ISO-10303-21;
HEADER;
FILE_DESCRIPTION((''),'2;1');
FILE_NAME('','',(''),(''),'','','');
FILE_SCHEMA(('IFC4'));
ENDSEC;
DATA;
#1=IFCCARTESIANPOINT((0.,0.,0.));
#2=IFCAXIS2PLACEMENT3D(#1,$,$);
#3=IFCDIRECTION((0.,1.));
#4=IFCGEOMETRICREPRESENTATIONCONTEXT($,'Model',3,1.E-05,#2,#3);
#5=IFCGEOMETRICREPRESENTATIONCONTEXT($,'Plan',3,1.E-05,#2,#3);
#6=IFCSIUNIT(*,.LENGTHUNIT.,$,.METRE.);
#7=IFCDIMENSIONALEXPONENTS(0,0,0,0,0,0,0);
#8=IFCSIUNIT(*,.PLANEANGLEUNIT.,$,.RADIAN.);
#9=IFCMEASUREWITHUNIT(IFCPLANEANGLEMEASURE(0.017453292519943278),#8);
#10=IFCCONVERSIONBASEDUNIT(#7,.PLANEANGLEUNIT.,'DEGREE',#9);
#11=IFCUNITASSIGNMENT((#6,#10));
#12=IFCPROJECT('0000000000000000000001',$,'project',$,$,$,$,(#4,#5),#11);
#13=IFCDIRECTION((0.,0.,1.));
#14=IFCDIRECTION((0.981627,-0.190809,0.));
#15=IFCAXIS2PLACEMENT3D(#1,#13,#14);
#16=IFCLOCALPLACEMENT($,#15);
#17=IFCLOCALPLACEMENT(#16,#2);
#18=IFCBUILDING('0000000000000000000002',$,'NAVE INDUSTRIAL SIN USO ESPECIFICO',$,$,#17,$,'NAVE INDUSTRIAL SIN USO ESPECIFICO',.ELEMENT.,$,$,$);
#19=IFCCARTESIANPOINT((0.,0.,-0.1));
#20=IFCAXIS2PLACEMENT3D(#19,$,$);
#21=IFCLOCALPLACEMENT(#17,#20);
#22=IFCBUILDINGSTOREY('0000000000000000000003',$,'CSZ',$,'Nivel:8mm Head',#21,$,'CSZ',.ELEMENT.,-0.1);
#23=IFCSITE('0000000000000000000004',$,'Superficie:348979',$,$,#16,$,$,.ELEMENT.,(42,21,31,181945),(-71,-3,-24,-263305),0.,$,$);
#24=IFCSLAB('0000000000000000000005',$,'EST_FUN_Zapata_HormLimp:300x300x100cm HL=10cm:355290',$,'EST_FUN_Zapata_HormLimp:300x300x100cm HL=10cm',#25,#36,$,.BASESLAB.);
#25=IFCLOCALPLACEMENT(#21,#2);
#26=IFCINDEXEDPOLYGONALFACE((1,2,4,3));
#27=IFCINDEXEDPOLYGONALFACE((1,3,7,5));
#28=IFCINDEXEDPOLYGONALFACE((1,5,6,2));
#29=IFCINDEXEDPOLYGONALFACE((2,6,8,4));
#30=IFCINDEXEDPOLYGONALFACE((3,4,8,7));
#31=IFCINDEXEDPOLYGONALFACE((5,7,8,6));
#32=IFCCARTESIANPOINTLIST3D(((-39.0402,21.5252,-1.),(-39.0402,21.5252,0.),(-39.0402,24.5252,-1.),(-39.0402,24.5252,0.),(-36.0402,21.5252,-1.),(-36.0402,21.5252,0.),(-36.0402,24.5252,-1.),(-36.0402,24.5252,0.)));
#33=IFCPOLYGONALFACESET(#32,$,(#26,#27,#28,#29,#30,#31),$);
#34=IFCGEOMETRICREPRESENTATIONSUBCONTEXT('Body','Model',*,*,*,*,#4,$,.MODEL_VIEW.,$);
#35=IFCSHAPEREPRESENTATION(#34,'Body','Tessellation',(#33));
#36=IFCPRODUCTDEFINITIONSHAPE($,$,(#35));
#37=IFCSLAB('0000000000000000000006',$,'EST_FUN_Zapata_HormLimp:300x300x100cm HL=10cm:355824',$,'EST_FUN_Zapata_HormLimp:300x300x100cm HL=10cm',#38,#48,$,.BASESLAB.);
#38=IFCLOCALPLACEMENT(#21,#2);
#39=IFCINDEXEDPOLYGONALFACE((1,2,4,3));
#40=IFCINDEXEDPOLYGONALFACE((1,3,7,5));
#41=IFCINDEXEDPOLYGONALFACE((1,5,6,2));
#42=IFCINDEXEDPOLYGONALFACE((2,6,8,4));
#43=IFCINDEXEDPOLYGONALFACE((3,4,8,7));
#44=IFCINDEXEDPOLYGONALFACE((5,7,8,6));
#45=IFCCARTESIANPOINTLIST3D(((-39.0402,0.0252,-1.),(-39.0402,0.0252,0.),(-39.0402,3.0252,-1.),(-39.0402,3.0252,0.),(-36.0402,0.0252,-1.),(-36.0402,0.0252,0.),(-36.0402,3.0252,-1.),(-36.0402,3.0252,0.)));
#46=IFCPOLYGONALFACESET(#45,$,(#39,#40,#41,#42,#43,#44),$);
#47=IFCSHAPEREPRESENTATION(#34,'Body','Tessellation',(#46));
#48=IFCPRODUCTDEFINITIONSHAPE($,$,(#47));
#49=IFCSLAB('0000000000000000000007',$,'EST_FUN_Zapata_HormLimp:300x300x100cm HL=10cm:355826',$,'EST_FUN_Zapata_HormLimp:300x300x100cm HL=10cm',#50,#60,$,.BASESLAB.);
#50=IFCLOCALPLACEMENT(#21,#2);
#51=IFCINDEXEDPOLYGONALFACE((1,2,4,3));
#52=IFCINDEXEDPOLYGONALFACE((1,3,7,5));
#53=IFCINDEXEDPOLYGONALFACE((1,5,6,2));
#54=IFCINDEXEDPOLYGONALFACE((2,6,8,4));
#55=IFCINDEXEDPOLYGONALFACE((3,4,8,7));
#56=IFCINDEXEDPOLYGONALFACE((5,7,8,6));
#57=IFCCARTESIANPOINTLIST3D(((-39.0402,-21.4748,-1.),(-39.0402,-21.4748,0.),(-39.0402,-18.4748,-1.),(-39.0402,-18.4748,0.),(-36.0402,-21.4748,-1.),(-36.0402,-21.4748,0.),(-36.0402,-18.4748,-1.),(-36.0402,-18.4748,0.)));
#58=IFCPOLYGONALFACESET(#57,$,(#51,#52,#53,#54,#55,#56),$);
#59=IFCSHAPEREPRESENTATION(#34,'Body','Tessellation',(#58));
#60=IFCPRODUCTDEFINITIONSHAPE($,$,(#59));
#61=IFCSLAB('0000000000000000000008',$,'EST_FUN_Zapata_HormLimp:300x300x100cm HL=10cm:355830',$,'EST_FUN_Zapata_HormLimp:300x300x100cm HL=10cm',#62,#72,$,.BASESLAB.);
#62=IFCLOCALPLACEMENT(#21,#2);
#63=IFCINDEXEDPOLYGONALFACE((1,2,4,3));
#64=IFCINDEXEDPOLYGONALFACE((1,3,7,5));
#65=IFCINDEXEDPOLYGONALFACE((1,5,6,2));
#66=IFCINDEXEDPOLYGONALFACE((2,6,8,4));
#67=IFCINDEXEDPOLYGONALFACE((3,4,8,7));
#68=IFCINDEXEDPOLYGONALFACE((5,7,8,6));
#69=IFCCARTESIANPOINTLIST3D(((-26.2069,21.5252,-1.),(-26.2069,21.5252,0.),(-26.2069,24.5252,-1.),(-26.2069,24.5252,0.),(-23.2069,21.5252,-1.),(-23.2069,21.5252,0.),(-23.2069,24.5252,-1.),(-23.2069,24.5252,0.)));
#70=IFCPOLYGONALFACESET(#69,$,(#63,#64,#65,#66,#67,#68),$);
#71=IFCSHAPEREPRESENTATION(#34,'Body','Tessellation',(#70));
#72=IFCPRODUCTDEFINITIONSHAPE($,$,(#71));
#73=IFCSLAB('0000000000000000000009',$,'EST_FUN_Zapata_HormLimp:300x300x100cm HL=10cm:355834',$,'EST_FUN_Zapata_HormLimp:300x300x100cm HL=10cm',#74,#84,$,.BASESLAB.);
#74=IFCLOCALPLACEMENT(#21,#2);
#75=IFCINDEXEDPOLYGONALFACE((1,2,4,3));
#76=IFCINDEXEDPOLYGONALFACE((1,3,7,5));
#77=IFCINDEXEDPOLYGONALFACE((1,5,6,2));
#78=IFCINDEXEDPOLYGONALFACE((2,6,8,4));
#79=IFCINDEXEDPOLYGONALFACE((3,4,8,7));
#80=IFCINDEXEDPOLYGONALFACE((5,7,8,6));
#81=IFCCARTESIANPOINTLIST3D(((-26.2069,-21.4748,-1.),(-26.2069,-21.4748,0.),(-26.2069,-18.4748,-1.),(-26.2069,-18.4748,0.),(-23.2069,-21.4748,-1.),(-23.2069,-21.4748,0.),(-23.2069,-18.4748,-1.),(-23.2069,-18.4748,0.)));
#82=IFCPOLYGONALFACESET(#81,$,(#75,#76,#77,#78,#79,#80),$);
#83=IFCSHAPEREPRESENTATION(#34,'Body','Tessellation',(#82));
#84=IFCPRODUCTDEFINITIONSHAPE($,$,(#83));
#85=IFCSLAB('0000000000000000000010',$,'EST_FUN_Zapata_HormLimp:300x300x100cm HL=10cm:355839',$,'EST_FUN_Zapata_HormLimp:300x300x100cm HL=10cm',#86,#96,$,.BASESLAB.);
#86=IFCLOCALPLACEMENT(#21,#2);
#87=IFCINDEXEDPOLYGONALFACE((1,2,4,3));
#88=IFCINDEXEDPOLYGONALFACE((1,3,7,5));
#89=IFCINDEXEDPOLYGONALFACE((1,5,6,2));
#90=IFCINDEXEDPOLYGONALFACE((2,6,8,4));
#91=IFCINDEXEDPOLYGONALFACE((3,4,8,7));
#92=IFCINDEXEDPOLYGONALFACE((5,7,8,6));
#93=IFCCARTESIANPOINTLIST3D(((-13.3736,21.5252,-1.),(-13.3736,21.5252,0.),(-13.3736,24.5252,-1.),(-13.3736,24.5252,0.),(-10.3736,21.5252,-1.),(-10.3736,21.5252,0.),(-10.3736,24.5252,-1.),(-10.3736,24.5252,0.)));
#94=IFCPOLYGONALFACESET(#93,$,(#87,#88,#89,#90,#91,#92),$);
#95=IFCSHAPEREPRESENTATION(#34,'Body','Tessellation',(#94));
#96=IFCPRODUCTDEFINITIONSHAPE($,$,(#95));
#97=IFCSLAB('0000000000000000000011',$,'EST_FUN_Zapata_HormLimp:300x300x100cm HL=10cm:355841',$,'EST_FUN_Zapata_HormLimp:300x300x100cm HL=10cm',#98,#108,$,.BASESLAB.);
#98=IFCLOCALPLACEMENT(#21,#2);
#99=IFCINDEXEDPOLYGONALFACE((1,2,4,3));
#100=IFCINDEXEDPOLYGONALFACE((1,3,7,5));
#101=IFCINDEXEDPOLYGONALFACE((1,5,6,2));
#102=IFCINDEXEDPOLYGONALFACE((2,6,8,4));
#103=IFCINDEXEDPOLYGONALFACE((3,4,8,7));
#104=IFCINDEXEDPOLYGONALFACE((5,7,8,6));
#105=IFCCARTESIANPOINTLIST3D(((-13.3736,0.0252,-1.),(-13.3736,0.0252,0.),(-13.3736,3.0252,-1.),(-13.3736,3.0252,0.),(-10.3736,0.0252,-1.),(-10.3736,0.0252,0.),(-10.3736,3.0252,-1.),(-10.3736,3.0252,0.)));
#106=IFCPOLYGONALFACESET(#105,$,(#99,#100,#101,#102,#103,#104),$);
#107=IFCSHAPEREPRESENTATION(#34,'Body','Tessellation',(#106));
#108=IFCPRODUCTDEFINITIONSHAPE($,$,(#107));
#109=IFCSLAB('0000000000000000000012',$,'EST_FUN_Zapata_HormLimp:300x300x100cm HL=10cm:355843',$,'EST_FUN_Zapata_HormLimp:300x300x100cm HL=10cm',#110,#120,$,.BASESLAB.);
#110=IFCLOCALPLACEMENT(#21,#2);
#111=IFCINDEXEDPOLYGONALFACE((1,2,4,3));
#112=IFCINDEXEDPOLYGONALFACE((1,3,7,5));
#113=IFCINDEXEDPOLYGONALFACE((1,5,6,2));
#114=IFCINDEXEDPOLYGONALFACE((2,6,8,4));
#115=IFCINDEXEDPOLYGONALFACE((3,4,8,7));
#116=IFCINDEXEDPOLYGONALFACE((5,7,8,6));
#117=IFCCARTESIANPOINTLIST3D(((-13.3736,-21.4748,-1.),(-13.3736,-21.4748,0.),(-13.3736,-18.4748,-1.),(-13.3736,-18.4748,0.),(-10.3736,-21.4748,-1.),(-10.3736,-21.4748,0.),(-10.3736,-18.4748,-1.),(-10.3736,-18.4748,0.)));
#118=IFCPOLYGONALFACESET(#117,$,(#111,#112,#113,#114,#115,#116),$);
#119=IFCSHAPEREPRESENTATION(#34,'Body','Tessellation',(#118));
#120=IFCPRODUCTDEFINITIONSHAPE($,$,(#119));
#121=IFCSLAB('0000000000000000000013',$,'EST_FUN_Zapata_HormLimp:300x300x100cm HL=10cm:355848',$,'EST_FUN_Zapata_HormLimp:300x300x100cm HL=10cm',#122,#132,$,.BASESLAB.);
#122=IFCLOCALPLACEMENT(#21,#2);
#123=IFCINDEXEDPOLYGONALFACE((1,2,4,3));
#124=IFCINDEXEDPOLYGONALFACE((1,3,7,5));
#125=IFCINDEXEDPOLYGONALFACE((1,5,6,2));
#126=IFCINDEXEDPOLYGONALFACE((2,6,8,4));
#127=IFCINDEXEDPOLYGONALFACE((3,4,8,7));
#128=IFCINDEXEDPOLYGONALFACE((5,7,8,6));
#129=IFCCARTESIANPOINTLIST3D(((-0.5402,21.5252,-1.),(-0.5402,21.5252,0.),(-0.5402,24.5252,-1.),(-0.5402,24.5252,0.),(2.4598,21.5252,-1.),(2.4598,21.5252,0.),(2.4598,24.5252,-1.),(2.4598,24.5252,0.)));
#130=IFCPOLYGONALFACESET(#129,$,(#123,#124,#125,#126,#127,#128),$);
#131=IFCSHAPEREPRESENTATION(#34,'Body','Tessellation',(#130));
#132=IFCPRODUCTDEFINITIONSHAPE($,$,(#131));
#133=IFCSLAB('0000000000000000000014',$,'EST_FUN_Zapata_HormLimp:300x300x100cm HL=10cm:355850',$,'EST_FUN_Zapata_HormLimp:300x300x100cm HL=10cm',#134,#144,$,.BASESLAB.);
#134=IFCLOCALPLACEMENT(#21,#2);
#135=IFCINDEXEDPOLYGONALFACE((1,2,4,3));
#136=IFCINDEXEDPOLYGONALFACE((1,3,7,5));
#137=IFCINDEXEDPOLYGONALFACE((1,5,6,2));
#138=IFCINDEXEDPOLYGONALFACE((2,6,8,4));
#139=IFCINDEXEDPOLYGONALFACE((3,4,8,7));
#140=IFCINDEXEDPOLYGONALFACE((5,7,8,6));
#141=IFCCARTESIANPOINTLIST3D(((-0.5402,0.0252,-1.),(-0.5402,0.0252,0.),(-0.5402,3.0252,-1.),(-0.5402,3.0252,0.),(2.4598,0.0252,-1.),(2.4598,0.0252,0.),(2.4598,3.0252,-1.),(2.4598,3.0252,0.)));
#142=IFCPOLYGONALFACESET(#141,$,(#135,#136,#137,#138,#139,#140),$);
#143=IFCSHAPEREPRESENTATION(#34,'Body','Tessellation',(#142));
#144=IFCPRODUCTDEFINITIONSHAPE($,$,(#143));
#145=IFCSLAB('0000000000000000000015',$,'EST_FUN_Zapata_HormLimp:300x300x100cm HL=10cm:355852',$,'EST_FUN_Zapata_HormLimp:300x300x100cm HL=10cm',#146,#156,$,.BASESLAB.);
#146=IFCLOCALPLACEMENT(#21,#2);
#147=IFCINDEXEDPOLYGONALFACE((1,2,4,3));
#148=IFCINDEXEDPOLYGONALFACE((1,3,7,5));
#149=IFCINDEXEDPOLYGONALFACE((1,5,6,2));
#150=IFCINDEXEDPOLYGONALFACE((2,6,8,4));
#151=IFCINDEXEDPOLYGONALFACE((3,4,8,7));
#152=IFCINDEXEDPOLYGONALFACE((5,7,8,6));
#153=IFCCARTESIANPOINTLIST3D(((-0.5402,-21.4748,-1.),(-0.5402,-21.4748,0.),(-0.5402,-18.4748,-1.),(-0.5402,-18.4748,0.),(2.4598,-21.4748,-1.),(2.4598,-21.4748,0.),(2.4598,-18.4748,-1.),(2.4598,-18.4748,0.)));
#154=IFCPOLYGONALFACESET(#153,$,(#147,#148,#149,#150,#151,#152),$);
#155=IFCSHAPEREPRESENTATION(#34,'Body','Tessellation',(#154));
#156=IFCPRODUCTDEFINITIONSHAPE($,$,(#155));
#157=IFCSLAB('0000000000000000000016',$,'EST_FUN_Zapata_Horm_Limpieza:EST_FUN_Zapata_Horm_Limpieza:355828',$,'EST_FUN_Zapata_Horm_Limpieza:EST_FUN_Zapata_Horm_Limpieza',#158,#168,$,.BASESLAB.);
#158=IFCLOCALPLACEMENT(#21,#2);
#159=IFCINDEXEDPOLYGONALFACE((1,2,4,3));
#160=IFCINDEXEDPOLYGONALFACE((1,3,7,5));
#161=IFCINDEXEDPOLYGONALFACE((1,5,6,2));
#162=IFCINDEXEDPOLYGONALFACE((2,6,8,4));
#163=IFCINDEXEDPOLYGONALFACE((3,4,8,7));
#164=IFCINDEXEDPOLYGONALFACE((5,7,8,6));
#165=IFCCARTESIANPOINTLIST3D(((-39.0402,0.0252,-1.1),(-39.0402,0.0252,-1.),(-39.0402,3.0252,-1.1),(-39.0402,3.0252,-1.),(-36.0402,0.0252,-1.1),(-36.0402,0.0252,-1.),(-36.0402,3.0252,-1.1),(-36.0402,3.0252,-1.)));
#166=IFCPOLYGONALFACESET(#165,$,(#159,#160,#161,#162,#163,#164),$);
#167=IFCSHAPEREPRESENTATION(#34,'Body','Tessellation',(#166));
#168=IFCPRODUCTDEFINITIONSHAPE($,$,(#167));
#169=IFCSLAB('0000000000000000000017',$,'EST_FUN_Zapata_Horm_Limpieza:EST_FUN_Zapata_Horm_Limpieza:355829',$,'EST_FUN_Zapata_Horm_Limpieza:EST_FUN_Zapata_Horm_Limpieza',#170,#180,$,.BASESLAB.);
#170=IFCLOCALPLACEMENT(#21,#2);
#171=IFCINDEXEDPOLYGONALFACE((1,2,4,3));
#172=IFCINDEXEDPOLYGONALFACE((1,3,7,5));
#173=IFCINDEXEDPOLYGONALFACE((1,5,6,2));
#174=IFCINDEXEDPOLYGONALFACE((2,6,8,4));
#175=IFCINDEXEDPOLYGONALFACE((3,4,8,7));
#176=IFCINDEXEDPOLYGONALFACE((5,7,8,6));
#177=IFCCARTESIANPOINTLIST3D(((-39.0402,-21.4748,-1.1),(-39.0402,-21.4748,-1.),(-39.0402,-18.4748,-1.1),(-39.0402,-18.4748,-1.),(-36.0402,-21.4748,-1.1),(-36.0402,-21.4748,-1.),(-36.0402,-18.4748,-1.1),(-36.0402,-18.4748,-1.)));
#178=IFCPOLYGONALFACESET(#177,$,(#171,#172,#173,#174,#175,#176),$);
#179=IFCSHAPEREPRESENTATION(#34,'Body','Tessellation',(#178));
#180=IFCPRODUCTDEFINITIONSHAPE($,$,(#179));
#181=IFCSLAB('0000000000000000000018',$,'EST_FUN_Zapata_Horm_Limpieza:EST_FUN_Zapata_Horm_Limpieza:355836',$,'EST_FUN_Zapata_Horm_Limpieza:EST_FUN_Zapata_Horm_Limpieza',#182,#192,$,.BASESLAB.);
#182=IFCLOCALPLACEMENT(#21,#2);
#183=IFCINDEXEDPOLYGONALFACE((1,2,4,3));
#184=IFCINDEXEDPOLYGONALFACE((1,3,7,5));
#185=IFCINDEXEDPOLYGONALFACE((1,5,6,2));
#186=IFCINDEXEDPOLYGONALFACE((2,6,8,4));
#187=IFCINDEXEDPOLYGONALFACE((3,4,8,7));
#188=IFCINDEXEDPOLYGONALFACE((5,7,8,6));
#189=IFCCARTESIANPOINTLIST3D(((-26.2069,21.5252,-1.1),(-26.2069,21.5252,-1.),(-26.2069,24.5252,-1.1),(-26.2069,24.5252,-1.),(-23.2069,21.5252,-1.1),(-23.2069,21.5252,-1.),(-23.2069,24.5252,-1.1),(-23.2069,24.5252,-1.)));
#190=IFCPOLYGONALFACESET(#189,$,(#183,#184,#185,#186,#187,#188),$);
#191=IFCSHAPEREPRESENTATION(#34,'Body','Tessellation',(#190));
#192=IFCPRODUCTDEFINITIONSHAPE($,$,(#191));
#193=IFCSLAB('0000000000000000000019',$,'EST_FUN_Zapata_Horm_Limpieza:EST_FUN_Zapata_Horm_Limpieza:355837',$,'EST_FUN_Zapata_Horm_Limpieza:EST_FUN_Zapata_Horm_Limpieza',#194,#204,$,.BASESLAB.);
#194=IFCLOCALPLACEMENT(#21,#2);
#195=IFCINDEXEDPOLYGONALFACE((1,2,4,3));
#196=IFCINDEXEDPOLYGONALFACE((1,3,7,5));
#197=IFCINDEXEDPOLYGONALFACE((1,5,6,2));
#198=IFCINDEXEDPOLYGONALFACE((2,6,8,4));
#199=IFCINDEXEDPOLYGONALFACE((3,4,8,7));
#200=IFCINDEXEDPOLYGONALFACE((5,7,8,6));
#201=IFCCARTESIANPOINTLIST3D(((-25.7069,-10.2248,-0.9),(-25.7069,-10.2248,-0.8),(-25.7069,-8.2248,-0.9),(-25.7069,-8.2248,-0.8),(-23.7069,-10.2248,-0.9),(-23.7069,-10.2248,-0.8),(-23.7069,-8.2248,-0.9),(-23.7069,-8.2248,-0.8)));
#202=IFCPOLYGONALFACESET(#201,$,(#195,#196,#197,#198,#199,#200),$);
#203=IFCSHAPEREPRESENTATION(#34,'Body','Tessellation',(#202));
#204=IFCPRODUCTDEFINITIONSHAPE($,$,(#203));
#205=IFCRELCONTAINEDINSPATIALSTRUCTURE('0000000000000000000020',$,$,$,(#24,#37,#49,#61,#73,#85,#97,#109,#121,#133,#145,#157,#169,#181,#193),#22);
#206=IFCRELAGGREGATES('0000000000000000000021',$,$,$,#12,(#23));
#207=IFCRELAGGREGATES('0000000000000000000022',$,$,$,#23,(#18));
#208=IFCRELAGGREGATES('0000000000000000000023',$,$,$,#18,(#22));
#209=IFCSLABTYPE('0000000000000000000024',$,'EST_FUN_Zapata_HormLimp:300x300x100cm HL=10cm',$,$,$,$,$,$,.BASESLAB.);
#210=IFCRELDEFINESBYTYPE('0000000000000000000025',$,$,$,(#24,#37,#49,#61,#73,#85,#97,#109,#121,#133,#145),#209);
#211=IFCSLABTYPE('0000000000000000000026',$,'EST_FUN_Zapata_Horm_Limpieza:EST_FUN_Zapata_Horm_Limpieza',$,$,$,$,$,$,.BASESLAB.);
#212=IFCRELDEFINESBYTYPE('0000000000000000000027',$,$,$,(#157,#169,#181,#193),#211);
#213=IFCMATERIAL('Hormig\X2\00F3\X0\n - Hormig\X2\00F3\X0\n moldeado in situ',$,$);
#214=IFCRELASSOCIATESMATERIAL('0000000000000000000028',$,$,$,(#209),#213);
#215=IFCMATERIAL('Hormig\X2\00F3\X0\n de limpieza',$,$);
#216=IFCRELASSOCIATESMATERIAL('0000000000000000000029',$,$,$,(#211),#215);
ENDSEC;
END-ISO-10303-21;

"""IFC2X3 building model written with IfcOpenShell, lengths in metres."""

from ifc_helpers import new_model, entity, si_unit, converted_unit, direction, frame, frame_2d, origin, origin_2d_with_axis, place, context, subcontext, project, spatial, rectangle, extrude, material, type_object, element, save


model = new_model("IFC2X3")

# Units and contexts
model_context = context("Model", 3, precision=1e-05, world=origin(), true_north=direction((0.0, 1.0)))
plan_context = context("Plan", 3, precision=1e-05, world=origin(), true_north=direction((0.0, 1.0)))
body_context = subcontext(model_context, "Body", "Model", "MODEL_VIEW")
ifc_project = project(units=[si_unit("LENGTHUNIT", "METRE"), converted_unit("PLANEANGLEUNIT", "DEGREE", entity("IfcPlaneAngleMeasure", 0.017453292519943278), si_unit("PLANEANGLEUNIT", "RADIAN"), dimensions=[0, 0, 0, 0, 0, 0, 0])], contexts=[model_context, plan_context])

# Site, building, storey
site_placement = place(None, frame((0.0, 0.0, 0.0), z_axis=(0.0, 0.0, 1.0), x_axis=(0.981627, -0.190809, 0.0)))
site = spatial("IfcSite", under=ifc_project, at=site_placement, Name="Superficie:348979", CompositionType="ELEMENT", RefLatitude=(42, 21, 31, 181945), RefLongitude=(-71, -3, -24, -263305), RefElevation=0.0)
building_placement = place(site_placement, origin())
building = spatial("IfcBuilding", under=site, at=building_placement, Name="NAVE INDUSTRIAL SIN USO ESPECIFICO", LongName="NAVE INDUSTRIAL SIN USO ESPECIFICO", CompositionType="ELEMENT")
storey_placement = place(building_placement, frame((0.0, 0.0, -0.1)))
storey = spatial("IfcBuildingStorey", under=building, at=storey_placement, Name="CSZ", ObjectType="Nivel:8mm Head", LongName="CSZ", CompositionType="ELEMENT", Elevation=-0.1)

# Slabs
ifc_material_1 = material(Name="Hormigón - Hormigón moldeado in situ")
slab_type_1 = type_object("IfcSlabType", Name="EST_FUN_Zapata_HormLimp:300x300x100cm HL=10cm", PredefinedType="BASESLAB", material=ifc_material_1)
slab_1_placement = place(storey_placement, origin())
element("IfcSlab", 1, at=slab_1_placement, inside=storey, type_object=slab_type_1, Name="EST_FUN_Zapata_HormLimp:300x300x100cm HL=10cm:355290", ObjectType="EST_FUN_Zapata_HormLimp:300x300x100cm HL=10cm", PredefinedType="BASESLAB", context=body_context, shape_type="SweptSolid", body=[
    extrude(rectangle(XDim=3.0, YDim=3.0, at=frame_2d((0.0, 0.0), x_axis=(1.0, 0.0))), frame((-37.5402, 23.0252, -1.0), z_axis=(0.0, 0.0, 1.0), x_axis=(-1.0, 0.0, 0.0)), (0.0, 0.0, 1.0), 1.0),
])
slab_2_placement = place(storey_placement, origin())
element("IfcSlab", 2, at=slab_2_placement, inside=storey, type_object=slab_type_1, Name="EST_FUN_Zapata_HormLimp:300x300x100cm HL=10cm:355824", ObjectType="EST_FUN_Zapata_HormLimp:300x300x100cm HL=10cm", PredefinedType="BASESLAB", context=body_context, shape_type="SweptSolid", body=[
    extrude(rectangle(XDim=3.0, YDim=3.0, at=origin_2d_with_axis()), frame((-37.5402, 1.5252, -1.0)), (0.0, 0.0, 1.0), 1.0),
])
slab_3_placement = place(storey_placement, origin())
element("IfcSlab", 3, at=slab_3_placement, inside=storey, type_object=slab_type_1, Name="EST_FUN_Zapata_HormLimp:300x300x100cm HL=10cm:355826", ObjectType="EST_FUN_Zapata_HormLimp:300x300x100cm HL=10cm", PredefinedType="BASESLAB", context=body_context, shape_type="SweptSolid", body=[
    extrude(rectangle(XDim=3.0, YDim=3.0, at=frame_2d((0.0, 0.0), x_axis=(1.0, 0.0))), frame((-37.5402, -19.9748, -1.0)), (0.0, 0.0, 1.0), 1.0),
])
slab_4_placement = place(storey_placement, origin())
element("IfcSlab", 4, at=slab_4_placement, inside=storey, type_object=slab_type_1, Name="EST_FUN_Zapata_HormLimp:300x300x100cm HL=10cm:355830", ObjectType="EST_FUN_Zapata_HormLimp:300x300x100cm HL=10cm", PredefinedType="BASESLAB", context=body_context, shape_type="SweptSolid", body=[
    extrude(rectangle(XDim=3.0, YDim=3.0, at=frame_2d((0.0, 0.0), x_axis=(1.0, 0.0))), frame((-24.7069, 23.0252, -1.0)), (0.0, 0.0, 1.0), 1.0),
])
slab_5_placement = place(storey_placement, origin())
element("IfcSlab", 5, at=slab_5_placement, inside=storey, type_object=slab_type_1, Name="EST_FUN_Zapata_HormLimp:300x300x100cm HL=10cm:355834", ObjectType="EST_FUN_Zapata_HormLimp:300x300x100cm HL=10cm", PredefinedType="BASESLAB", context=body_context, shape_type="SweptSolid", body=[
    extrude(rectangle(XDim=3.0, YDim=3.0, at=frame_2d((0.0, 0.0), x_axis=(1.0, 0.0))), frame((-24.7069, -19.9748, -1.0)), (0.0, 0.0, 1.0), 1.0),
])
slab_6_placement = place(storey_placement, origin())
element("IfcSlab", 6, at=slab_6_placement, inside=storey, type_object=slab_type_1, Name="EST_FUN_Zapata_HormLimp:300x300x100cm HL=10cm:355839", ObjectType="EST_FUN_Zapata_HormLimp:300x300x100cm HL=10cm", PredefinedType="BASESLAB", context=body_context, shape_type="SweptSolid", body=[
    extrude(rectangle(XDim=3.0, YDim=3.0, at=frame_2d((0.0, 0.0), x_axis=(1.0, 0.0))), frame((-11.8736, 23.0252, -1.0)), (0.0, 0.0, 1.0), 1.0),
])
slab_7_placement = place(storey_placement, origin())
element("IfcSlab", 7, at=slab_7_placement, inside=storey, type_object=slab_type_1, Name="EST_FUN_Zapata_HormLimp:300x300x100cm HL=10cm:355841", ObjectType="EST_FUN_Zapata_HormLimp:300x300x100cm HL=10cm", PredefinedType="BASESLAB", context=body_context, shape_type="SweptSolid", body=[
    extrude(rectangle(XDim=3.0, YDim=3.0, at=origin_2d_with_axis()), frame((-11.8736, 1.5252, -1.0)), (0.0, 0.0, 1.0), 1.0),
])
slab_8_placement = place(storey_placement, origin())
element("IfcSlab", 8, at=slab_8_placement, inside=storey, type_object=slab_type_1, Name="EST_FUN_Zapata_HormLimp:300x300x100cm HL=10cm:355843", ObjectType="EST_FUN_Zapata_HormLimp:300x300x100cm HL=10cm", PredefinedType="BASESLAB", context=body_context, shape_type="SweptSolid", body=[
    extrude(rectangle(XDim=3.0, YDim=3.0, at=frame_2d((0.0, 0.0), x_axis=(1.0, 0.0))), frame((-11.8736, -19.9748, -1.0)), (0.0, 0.0, 1.0), 1.0),
])
slab_9_placement = place(storey_placement, origin())
element("IfcSlab", 9, at=slab_9_placement, inside=storey, type_object=slab_type_1, Name="EST_FUN_Zapata_HormLimp:300x300x100cm HL=10cm:355848", ObjectType="EST_FUN_Zapata_HormLimp:300x300x100cm HL=10cm", PredefinedType="BASESLAB", context=body_context, shape_type="SweptSolid", body=[
    extrude(rectangle(XDim=3.0, YDim=3.0, at=frame_2d((0.0, 0.0), x_axis=(1.0, 0.0))), frame((0.9598, 23.0252, -1.0)), (0.0, 0.0, 1.0), 1.0),
])
slab_10_placement = place(storey_placement, origin())
element("IfcSlab", 10, at=slab_10_placement, inside=storey, type_object=slab_type_1, Name="EST_FUN_Zapata_HormLimp:300x300x100cm HL=10cm:355850", ObjectType="EST_FUN_Zapata_HormLimp:300x300x100cm HL=10cm", PredefinedType="BASESLAB", context=body_context, shape_type="SweptSolid", body=[
    extrude(rectangle(XDim=3.0, YDim=3.0, at=origin_2d_with_axis()), frame((0.9598, 1.5252, -1.0)), (0.0, 0.0, 1.0), 1.0),
])
slab_11_placement = place(storey_placement, origin())
element("IfcSlab", 11, at=slab_11_placement, inside=storey, type_object=slab_type_1, Name="EST_FUN_Zapata_HormLimp:300x300x100cm HL=10cm:355852", ObjectType="EST_FUN_Zapata_HormLimp:300x300x100cm HL=10cm", PredefinedType="BASESLAB", context=body_context, shape_type="SweptSolid", body=[
    extrude(rectangle(XDim=3.0, YDim=3.0, at=frame_2d((0.0, 0.0), x_axis=(1.0, 0.0))), frame((0.9598, -19.9748, -1.0)), (0.0, 0.0, 1.0), 1.0),
])
ifc_material_2 = material(Name="Hormigón de limpieza")
slab_type_2 = type_object("IfcSlabType", Name="EST_FUN_Zapata_Horm_Limpieza:EST_FUN_Zapata_Horm_Limpieza", PredefinedType="BASESLAB", material=ifc_material_2)
slab_12_placement = place(storey_placement, frame((0.0, 0.0, -1.0)))
element("IfcSlab", 12, at=slab_12_placement, inside=storey, type_object=slab_type_2, Name="EST_FUN_Zapata_Horm_Limpieza:EST_FUN_Zapata_Horm_Limpieza:355828", ObjectType="EST_FUN_Zapata_Horm_Limpieza:EST_FUN_Zapata_Horm_Limpieza", PredefinedType="BASESLAB", context=body_context, shape_type="SweptSolid", body=[
    extrude(rectangle(XDim=3.0, YDim=3.0, at=origin_2d_with_axis()), frame((-37.5402, 1.5252, -0.1)), (0.0, 0.0, 1.0), 0.1),
])
slab_13_placement = place(storey_placement, frame((0.0, 0.0, -1.0)))
element("IfcSlab", 13, at=slab_13_placement, inside=storey, type_object=slab_type_2, Name="EST_FUN_Zapata_Horm_Limpieza:EST_FUN_Zapata_Horm_Limpieza:355829", ObjectType="EST_FUN_Zapata_Horm_Limpieza:EST_FUN_Zapata_Horm_Limpieza", PredefinedType="BASESLAB", context=body_context, shape_type="SweptSolid", body=[
    extrude(rectangle(XDim=3.0, YDim=3.0, at=frame_2d((0.0, 0.0), x_axis=(1.0, 0.0))), frame((-37.5402, -19.9748, -0.1)), (0.0, 0.0, 1.0), 0.1),
])
slab_14_placement = place(storey_placement, frame((0.0, 0.0, -1.0)))
element("IfcSlab", 14, at=slab_14_placement, inside=storey, type_object=slab_type_2, Name="EST_FUN_Zapata_Horm_Limpieza:EST_FUN_Zapata_Horm_Limpieza:355836", ObjectType="EST_FUN_Zapata_Horm_Limpieza:EST_FUN_Zapata_Horm_Limpieza", PredefinedType="BASESLAB", context=body_context, shape_type="SweptSolid", body=[
    extrude(rectangle(XDim=3.0, YDim=3.0, at=frame_2d((0.0, 0.0), x_axis=(1.0, 0.0))), frame((-24.7069, 23.0252, -0.1)), (0.0, 0.0, 1.0), 0.1),
])
slab_15_placement = place(storey_placement, frame((0.0, 0.0, -0.8)))
element("IfcSlab", 15, at=slab_15_placement, inside=storey, type_object=slab_type_2, Name="EST_FUN_Zapata_Horm_Limpieza:EST_FUN_Zapata_Horm_Limpieza:355837", ObjectType="EST_FUN_Zapata_Horm_Limpieza:EST_FUN_Zapata_Horm_Limpieza", PredefinedType="BASESLAB", context=body_context, shape_type="SweptSolid", body=[
    extrude(rectangle(XDim=2.0, YDim=2.0, at=frame_2d((0.0, 0.0), x_axis=(1.0, 0.0))), frame((-24.7069, -9.2248, -0.1)), (0.0, 0.0, 1.0), 0.1),
])

save(model, "model.ifc")
